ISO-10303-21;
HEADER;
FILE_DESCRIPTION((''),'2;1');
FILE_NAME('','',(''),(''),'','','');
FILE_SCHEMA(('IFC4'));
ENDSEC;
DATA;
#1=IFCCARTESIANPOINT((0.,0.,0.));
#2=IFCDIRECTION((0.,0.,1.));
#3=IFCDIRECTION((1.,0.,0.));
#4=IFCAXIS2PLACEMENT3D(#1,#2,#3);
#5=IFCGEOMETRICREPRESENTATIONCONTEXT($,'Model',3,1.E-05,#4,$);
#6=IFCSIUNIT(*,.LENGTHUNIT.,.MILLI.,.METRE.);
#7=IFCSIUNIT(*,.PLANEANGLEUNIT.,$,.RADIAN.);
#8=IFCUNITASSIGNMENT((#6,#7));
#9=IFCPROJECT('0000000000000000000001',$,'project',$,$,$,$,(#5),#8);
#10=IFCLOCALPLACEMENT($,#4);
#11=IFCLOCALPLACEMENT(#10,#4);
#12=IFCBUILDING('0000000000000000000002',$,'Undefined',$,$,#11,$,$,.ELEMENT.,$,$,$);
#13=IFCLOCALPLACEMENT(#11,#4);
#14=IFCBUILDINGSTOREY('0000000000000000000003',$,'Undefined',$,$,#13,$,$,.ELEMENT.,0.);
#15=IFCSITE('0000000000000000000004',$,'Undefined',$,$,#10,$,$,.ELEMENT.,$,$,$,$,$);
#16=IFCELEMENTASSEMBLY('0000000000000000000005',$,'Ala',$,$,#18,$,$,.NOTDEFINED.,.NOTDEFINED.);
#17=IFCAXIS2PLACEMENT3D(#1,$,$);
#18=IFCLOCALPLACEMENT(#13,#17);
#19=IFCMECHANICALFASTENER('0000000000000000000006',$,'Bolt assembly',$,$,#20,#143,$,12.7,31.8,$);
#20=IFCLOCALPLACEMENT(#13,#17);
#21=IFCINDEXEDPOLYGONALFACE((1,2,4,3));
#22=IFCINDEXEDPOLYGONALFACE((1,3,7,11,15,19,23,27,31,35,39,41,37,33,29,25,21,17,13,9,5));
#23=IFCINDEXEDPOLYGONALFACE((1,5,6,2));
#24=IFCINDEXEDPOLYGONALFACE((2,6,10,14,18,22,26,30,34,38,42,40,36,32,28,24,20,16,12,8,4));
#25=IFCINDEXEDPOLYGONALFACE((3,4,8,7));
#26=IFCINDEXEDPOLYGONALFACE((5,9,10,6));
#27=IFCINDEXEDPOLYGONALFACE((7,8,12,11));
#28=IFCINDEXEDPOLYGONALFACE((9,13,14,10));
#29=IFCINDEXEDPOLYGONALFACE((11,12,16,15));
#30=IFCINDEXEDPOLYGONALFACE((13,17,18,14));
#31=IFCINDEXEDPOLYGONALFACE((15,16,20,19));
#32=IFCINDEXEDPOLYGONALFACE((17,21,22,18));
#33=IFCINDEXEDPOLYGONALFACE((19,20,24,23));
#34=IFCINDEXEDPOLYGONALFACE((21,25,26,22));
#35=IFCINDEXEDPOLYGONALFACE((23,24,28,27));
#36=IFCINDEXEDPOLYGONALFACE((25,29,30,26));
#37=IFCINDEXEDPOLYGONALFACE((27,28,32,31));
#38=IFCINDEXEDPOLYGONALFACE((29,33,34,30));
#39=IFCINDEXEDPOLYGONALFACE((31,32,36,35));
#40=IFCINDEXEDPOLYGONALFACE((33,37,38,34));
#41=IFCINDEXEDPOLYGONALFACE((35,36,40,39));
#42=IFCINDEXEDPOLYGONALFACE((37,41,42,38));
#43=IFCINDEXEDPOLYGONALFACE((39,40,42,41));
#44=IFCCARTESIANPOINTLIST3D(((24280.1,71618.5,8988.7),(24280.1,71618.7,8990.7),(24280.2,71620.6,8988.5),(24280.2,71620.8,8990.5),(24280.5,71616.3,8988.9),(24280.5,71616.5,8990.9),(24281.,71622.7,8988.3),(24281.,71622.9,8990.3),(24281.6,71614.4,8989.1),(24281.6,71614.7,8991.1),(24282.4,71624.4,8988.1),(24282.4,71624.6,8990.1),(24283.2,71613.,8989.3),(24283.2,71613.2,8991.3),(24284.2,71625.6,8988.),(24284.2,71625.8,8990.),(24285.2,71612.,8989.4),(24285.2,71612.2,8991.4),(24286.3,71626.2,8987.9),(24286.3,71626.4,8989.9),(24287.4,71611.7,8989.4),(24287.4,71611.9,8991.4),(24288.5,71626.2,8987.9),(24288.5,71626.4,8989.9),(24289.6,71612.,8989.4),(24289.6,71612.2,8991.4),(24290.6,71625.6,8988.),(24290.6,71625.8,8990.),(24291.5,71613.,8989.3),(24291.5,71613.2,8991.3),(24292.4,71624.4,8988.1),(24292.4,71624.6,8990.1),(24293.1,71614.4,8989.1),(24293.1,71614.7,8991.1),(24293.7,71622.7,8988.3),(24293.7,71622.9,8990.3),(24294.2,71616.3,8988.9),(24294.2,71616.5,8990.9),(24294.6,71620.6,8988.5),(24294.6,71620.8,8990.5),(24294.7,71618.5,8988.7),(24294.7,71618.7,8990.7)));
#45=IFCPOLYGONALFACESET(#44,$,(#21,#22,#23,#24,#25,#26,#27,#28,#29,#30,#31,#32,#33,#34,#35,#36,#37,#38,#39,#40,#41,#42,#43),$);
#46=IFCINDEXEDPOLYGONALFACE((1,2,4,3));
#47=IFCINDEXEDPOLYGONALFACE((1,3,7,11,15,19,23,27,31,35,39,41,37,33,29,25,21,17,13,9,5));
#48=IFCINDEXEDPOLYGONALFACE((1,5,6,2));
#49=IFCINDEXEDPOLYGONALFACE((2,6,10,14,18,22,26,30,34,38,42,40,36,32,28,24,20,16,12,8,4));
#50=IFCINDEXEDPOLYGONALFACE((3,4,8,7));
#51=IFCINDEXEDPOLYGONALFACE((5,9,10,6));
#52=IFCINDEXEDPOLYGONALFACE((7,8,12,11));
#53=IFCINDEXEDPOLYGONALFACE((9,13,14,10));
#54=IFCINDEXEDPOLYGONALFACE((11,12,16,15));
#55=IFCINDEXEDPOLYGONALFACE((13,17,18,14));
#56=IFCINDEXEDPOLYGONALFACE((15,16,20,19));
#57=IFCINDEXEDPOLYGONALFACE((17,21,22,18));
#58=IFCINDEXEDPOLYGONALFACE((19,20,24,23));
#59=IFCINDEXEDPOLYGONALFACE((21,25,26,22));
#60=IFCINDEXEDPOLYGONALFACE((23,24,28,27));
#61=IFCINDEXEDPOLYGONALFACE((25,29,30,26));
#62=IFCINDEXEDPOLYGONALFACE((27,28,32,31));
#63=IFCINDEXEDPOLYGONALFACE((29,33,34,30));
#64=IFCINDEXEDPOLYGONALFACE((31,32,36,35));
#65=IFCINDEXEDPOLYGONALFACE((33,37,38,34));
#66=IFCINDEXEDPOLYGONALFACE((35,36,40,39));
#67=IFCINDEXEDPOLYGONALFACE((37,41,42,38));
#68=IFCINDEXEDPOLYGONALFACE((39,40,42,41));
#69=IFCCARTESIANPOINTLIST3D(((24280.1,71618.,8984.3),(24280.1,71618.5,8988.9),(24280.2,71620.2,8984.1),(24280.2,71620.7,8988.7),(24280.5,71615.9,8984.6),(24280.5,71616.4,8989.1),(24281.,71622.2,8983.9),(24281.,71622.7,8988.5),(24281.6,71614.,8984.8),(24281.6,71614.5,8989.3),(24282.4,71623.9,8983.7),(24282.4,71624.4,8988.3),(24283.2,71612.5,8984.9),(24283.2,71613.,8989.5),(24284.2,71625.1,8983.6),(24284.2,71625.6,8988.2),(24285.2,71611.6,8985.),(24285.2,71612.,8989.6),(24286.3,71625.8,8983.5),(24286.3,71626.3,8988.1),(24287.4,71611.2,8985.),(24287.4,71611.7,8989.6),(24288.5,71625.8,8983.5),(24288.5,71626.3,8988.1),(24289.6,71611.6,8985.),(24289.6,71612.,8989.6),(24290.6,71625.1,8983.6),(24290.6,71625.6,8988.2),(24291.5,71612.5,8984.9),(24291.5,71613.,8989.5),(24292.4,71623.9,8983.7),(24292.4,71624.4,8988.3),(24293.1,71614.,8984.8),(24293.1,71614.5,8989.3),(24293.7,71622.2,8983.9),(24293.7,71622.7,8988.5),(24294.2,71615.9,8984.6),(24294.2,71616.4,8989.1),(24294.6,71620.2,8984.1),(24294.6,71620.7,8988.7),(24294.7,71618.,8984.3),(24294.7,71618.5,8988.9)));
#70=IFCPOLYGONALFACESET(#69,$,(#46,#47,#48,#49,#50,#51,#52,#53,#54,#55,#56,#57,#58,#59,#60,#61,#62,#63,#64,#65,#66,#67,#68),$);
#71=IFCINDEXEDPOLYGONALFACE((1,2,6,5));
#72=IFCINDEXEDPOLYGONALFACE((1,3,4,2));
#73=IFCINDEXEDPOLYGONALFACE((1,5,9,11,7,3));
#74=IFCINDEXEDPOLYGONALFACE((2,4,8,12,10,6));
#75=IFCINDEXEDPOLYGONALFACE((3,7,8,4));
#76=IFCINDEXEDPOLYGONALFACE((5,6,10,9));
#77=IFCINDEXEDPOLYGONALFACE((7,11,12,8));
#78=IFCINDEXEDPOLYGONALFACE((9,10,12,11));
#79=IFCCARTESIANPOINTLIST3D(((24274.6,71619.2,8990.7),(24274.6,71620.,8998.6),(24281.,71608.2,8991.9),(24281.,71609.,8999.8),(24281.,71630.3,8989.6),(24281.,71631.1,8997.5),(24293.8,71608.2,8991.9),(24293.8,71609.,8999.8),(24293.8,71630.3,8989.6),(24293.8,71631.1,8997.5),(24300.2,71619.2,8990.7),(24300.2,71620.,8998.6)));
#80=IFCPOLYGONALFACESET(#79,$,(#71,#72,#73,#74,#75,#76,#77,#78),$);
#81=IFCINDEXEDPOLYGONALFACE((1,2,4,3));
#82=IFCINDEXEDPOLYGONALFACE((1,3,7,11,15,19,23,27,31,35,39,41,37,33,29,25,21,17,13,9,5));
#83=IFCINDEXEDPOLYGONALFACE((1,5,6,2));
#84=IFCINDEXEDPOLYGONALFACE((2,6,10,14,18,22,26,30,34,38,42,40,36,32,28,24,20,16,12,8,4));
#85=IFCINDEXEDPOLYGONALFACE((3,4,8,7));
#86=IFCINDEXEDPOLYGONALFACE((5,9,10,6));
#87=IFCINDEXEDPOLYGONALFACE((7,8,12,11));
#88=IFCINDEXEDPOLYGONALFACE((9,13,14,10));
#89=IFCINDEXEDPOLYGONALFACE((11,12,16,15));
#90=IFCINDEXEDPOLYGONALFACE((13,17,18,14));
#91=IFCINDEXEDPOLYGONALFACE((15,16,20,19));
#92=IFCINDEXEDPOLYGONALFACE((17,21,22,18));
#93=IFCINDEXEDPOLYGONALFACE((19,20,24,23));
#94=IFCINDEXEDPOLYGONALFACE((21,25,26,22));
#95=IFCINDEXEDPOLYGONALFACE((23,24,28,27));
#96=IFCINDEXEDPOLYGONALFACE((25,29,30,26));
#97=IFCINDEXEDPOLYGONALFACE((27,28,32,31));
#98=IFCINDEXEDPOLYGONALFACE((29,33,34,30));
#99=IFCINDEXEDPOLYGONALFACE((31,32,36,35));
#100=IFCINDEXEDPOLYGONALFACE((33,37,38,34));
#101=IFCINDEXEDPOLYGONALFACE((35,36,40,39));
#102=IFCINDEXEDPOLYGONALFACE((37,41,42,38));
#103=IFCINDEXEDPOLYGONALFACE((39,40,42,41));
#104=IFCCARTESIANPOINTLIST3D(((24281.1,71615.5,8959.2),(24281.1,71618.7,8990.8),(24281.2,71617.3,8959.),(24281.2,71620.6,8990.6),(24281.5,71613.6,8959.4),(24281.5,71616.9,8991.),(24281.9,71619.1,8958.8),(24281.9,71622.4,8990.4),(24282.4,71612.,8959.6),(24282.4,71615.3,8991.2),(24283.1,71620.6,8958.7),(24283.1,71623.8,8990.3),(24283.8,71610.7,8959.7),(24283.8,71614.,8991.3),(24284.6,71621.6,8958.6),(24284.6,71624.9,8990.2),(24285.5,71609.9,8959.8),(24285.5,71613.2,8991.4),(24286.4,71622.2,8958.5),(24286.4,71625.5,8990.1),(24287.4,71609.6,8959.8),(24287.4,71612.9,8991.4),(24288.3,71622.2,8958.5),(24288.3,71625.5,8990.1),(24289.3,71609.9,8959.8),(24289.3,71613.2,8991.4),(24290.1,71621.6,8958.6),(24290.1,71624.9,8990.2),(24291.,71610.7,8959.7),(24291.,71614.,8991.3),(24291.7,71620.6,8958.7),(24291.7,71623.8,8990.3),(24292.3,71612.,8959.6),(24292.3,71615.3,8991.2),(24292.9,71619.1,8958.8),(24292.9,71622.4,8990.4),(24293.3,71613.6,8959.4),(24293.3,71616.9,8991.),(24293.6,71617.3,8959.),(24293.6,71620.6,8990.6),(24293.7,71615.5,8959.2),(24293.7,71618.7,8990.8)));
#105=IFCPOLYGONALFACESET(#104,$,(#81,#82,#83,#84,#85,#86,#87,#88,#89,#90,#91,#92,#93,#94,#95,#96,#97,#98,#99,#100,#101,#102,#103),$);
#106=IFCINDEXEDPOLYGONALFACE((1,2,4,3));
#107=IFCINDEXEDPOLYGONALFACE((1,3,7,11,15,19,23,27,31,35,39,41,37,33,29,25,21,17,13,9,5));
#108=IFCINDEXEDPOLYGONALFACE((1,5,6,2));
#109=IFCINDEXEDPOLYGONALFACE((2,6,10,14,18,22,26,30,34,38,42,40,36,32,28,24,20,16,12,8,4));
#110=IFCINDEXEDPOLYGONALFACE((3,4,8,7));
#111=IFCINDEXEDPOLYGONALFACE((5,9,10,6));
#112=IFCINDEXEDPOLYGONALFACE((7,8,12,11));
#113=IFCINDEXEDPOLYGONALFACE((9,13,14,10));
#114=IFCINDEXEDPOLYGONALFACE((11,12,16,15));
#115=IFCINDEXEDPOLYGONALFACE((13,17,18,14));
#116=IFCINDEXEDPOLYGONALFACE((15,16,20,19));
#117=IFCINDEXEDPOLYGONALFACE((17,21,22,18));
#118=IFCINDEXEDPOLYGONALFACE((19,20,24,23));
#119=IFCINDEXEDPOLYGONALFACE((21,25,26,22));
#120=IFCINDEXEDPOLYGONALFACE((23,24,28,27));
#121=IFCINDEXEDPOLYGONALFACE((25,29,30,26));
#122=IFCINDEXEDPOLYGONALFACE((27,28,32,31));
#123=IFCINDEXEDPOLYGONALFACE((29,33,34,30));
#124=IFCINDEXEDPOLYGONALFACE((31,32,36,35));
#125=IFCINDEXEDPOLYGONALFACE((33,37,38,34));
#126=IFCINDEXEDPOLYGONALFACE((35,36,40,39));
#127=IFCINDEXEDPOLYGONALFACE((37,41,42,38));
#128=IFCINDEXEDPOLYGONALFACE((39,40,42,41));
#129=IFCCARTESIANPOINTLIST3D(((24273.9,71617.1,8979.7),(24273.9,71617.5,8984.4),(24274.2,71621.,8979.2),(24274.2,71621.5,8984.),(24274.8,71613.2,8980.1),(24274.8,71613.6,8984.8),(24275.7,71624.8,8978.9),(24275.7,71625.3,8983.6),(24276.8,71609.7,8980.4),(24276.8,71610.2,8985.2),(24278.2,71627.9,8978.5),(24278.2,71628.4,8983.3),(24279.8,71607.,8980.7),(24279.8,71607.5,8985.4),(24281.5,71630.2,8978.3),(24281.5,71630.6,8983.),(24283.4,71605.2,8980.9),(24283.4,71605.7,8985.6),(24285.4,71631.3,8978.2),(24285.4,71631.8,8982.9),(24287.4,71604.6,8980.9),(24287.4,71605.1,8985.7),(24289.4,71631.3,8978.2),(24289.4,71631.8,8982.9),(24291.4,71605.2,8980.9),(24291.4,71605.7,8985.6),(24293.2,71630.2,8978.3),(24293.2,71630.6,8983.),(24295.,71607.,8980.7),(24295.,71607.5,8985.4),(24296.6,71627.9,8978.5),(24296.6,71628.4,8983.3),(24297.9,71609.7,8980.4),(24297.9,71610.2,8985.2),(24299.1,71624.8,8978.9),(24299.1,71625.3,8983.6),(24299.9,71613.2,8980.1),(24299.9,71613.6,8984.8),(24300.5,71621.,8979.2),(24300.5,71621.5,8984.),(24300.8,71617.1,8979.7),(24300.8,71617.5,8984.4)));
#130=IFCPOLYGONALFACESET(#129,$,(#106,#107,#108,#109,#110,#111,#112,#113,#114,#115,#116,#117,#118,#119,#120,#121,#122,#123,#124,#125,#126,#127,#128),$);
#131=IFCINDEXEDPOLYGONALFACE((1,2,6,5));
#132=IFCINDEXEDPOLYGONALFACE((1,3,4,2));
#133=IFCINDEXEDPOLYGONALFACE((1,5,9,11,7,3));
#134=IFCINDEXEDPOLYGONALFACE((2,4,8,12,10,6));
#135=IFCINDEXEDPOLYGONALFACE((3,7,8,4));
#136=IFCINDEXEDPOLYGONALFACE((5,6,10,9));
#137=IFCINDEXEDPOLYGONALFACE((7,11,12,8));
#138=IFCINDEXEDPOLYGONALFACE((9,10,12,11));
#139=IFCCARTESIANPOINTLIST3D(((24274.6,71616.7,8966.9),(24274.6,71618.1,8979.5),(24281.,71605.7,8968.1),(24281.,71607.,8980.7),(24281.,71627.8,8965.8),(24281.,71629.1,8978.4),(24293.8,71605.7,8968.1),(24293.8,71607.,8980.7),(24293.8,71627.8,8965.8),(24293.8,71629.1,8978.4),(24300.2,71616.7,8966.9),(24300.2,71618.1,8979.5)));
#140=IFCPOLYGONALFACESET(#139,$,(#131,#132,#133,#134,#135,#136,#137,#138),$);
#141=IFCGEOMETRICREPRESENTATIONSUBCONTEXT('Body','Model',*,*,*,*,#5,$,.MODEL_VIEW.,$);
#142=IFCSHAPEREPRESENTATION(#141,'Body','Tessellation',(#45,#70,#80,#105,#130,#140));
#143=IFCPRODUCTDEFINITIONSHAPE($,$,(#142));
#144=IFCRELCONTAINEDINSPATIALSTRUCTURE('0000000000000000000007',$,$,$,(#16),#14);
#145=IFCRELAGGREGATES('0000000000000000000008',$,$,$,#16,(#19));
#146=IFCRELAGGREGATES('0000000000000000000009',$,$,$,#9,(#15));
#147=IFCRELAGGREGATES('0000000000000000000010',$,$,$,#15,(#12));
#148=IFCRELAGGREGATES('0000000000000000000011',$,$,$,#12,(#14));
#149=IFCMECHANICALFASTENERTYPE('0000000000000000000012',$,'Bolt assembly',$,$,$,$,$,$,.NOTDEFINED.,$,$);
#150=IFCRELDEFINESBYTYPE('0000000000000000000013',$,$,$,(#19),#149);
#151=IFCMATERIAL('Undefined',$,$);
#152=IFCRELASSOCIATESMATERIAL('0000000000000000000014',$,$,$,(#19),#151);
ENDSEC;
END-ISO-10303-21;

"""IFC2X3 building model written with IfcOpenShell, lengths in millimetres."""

from ifc_helpers import new_model, si_unit, frame, origin_with_axes, origin_2d_with_axis, place, context, subcontext, project, spatial, polyline, circle, outline, extrude, source, transform, mapped, material, type_object, element, aggregate, save


model = new_model("IFC2X3")

# Units and contexts
model_context = context("Model", 3, precision=1e-05, world=origin_with_axes())
body_context = subcontext(model_context, "Body", "Model", "MODEL_VIEW")
ifc_project = project(units=[si_unit("LENGTHUNIT", "METRE", prefix="MILLI"), si_unit("PLANEANGLEUNIT", "RADIAN")], contexts=[model_context])

# Site, building, storey
site_placement = place(None, origin_with_axes())
site = spatial("IfcSite", under=ifc_project, at=site_placement, Name="Undefined", CompositionType="ELEMENT")
building_placement = place(site_placement, origin_with_axes())
building = spatial("IfcBuilding", under=site, at=building_placement, Name="Undefined", CompositionType="ELEMENT")
storey_placement = place(building_placement, origin_with_axes())
storey = spatial("IfcBuildingStorey", under=building, at=storey_placement, Name="Undefined", CompositionType="ELEMENT", Elevation=0.0)

# Shared definitions
ifc_material_1 = material(Name="Undefined")
mechanical_fastener_type = type_object("IfcMechanicalFastenerType", Name="Bolt assembly")

# Shared definitions
shared_shape_1 = source(origin_with_axes(), body_context, "Body", "SweptSolid", [
    extrude(circle(Radius=7.3, at=origin_2d_with_axis()), frame((0.0, -1.9, 0.0), z_axis=(0.0, 1.0, 0.0), x_axis=(1.0, 0.0, 0.0)), (0.0, 0.0, 1.0), 2.0),
    extrude(circle(Radius=7.3, at=origin_2d_with_axis()), frame((0.0, -0.1, 0.0), z_axis=(0.0, 1.0, 0.0), x_axis=(1.0, 0.0, 0.0)), (0.0, 0.0, 1.0), 4.6),
    extrude(outline(polyline([(11.1, -6.4), (11.1, 6.4), (0.0, 12.8), (-11.1, 6.4), (-11.1, -6.4), (0.0, -12.8), (11.1, -6.4)])), frame((0.0, -9.9, 0.0), z_axis=(0.0, 1.0, 0.0), x_axis=(1.0, 0.0, 0.0)), (0.0, 0.0, 1.0), 7.9),
    extrude(circle(Radius=6.3, at=origin_2d_with_axis()), frame((0.0, -2.0, 0.0), z_axis=(0.0, 1.0, 0.0), x_axis=(1.0, 0.0, 0.0)), (0.0, 0.0, 1.0), 31.8),
    extrude(circle(Radius=13.5, at=origin_2d_with_axis()), frame((0.0, 4.5, 0.0), z_axis=(0.0, 1.0, 0.0), x_axis=(1.0, 0.0, 0.0)), (0.0, 0.0, 1.0), 4.8),
    extrude(outline(polyline([(11.1, -6.4), (11.1, 6.4), (0.0, 12.8), (-11.1, 6.4), (-11.1, -6.4), (0.0, -12.8), (11.1, -6.4)])), frame((0.0, 9.3, 0.0), z_axis=(0.0, 1.0, 0.0), x_axis=(1.0, 0.0, 0.0)), (0.0, 0.0, 1.0), 12.7),
])

# Element assembly, mechanical fastener
assembly_1_placement = place(storey_placement, origin_with_axes())
assembly_1 = element("IfcElementAssembly", 1, at=assembly_1_placement, inside=storey, Name="Ala", AssemblyPlace="NOTDEFINED", PredefinedType="NOTDEFINED")
mechanical_fastener_1_placement = place(assembly_1_placement, frame((24287.4, 71619.0, 8988.8), z_axis=(1.0, 0.0, 0.0), x_axis=(0.0, -0.994665, 0.103162)))
mechanical_fastener_1 = element("IfcMechanicalFastener", 2, at=mechanical_fastener_1_placement, type_object=mechanical_fastener_type, material=ifc_material_1, Name="Bolt assembly", NominalDiameter=12.7, NominalLength=31.8, context=body_context, shape_type="MappedRepresentation", body=[
    mapped(shared_shape_1, transform((0.0, 0.0, 0.0))),
])
aggregate(assembly_1, [mechanical_fastener_1])

save(model, "model.ifc")
